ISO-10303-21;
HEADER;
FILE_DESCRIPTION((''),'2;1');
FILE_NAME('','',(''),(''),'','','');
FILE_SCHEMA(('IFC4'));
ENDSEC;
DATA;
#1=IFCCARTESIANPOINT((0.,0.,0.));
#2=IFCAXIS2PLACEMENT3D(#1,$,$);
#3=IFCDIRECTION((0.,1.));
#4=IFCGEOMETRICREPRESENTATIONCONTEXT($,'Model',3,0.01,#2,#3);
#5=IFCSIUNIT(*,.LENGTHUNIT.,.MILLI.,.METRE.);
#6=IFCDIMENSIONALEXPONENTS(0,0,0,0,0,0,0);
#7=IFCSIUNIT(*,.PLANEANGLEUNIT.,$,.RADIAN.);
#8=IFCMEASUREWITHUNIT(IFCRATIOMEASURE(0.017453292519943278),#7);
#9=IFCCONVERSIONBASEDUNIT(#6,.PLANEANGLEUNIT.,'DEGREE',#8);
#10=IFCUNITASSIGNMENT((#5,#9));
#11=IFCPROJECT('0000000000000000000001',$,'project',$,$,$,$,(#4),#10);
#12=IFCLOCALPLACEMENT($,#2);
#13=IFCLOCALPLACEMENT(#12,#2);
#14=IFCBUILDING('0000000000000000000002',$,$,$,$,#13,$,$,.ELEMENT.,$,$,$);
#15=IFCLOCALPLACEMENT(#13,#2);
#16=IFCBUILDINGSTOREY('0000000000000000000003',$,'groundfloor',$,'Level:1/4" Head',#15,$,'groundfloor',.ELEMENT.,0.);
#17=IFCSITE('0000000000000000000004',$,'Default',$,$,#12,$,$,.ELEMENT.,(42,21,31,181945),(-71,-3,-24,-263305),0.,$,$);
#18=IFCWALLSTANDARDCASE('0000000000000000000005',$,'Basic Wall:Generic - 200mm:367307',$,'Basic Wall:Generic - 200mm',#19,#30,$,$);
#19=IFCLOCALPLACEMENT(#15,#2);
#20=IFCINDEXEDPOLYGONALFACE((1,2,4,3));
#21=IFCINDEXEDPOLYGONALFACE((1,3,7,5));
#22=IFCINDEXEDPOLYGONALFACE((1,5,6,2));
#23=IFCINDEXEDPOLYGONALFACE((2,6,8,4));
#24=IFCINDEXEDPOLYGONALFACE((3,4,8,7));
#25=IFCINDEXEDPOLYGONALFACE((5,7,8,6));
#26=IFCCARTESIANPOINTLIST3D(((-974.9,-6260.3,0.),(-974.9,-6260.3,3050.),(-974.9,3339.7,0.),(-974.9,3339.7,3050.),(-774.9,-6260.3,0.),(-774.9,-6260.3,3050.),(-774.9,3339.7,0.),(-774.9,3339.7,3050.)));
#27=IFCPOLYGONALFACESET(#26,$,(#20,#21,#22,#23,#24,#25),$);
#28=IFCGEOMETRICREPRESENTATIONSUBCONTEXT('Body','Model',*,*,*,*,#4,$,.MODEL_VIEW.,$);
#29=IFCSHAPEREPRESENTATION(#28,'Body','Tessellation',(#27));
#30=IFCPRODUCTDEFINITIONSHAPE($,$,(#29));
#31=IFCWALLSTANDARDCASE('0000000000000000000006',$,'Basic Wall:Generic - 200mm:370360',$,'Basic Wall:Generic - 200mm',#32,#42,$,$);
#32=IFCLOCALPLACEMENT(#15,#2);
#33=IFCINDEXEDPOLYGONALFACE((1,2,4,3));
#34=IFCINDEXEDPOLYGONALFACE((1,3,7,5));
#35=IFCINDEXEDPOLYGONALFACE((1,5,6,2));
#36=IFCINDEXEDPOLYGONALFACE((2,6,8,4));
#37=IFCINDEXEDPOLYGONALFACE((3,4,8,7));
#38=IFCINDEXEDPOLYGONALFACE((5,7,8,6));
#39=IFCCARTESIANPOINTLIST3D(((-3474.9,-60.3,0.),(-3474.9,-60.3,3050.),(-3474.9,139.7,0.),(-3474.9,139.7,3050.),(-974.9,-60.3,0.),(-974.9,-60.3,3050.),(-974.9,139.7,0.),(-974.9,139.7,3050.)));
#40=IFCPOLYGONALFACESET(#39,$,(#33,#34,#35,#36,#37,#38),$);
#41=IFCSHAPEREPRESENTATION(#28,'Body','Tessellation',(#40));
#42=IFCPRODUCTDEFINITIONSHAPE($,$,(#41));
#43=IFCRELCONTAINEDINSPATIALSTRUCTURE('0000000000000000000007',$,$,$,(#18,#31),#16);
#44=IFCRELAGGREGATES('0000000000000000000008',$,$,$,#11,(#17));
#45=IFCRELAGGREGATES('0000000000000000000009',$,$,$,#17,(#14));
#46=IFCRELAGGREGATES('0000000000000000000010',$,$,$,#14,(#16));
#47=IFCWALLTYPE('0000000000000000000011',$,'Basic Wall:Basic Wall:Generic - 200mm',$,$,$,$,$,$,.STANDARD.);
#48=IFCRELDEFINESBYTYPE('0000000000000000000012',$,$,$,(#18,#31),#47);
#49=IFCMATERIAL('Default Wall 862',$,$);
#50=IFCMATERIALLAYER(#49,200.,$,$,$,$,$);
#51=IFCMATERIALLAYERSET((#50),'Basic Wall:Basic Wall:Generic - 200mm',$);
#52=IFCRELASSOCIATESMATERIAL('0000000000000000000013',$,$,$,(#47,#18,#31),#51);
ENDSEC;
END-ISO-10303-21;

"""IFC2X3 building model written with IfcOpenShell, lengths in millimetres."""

from ifc_helpers import new_model, entity, si_unit, converted_unit, direction, frame, frame_2d, origin, place, context, subcontext, project, spatial, rectangle, extrude, material, layer, layer_set, layer_usage, type_object, element, save


model = new_model("IFC2X3")

# Units and contexts
model_context = context("Model", 3, precision=0.01, world=origin(), true_north=direction((0.0, 1.0)))
body_context = subcontext(model_context, "Body", "Model", "MODEL_VIEW")
ifc_project = project(units=[si_unit("LENGTHUNIT", "METRE", prefix="MILLI"), converted_unit("PLANEANGLEUNIT", "DEGREE", entity("IfcRatioMeasure", 0.017453292519943278), si_unit("PLANEANGLEUNIT", "RADIAN"), dimensions=[0, 0, 0, 0, 0, 0, 0])], contexts=[model_context])

# Site, building, storey
site_placement = place(None, origin())
site = spatial("IfcSite", under=ifc_project, at=site_placement, Name="Default", CompositionType="ELEMENT", RefLatitude=(42, 21, 31, 181945), RefLongitude=(-71, -3, -24, -263305), RefElevation=0.0)
building_placement = place(site_placement, origin())
building = spatial("IfcBuilding", under=site, at=building_placement, CompositionType="ELEMENT")
storey_placement = place(building_placement, origin())
storey = spatial("IfcBuildingStorey", under=building, at=storey_placement, Name="groundfloor", ObjectType="Level:1/4\" Head", LongName="groundfloor", CompositionType="ELEMENT", Elevation=0.0)

# Shared definitions
ifc_material_1 = material(Name="Default Wall 862")

# Walls
ifc_layer_1 = layer(ifc_material_1, 200.0)
ifc_layer_set_1 = layer_set([ifc_layer_1], Name="Basic Wall:Basic Wall:Generic - 200mm")
wall_type_1 = type_object("IfcWallType", Name="Basic Wall:Basic Wall:Generic - 200mm", PredefinedType="STANDARD", material=ifc_layer_set_1)
ifc_layer_usage_1 = layer_usage(ifc_layer_set_1, "AXIS2", "NEGATIVE", 100.0)
wall_1_placement = place(storey_placement, frame((-874.9, -6260.3, 0.0), z_axis=(0.0, 0.0, 1.0), x_axis=(0.0, 1.0, 0.0)))
element("IfcWallStandardCase", 1, at=wall_1_placement, inside=storey, type_object=wall_type_1, material=ifc_layer_usage_1, Name="Basic Wall:Generic - 200mm:367307", ObjectType="Basic Wall:Generic - 200mm", context=body_context, shape_type="SweptSolid", body=[
    extrude(rectangle(XDim=9600.0, YDim=200.0, at=frame_2d((4800.0, 0.0), x_axis=(-1.0, 0.0))), origin(), (0.0, 0.0, 1.0), 3050.0),
])
ifc_layer_usage_2 = layer_usage(ifc_layer_set_1, "AXIS2", "NEGATIVE", 100.0)
wall_2_placement = place(storey_placement, frame((-3474.9, 39.7, 0.0)))
element("IfcWallStandardCase", 2, at=wall_2_placement, inside=storey, type_object=wall_type_1, material=ifc_layer_usage_2, Name="Basic Wall:Generic - 200mm:370360", ObjectType="Basic Wall:Generic - 200mm", context=body_context, shape_type="SweptSolid", body=[
    extrude(rectangle(XDim=2500.0, YDim=200.0, at=frame_2d((1250.0, 0.0), x_axis=(-1.0, 0.0))), origin(), (0.0, 0.0, 1.0), 3050.0),
])

save(model, "model.ifc")
